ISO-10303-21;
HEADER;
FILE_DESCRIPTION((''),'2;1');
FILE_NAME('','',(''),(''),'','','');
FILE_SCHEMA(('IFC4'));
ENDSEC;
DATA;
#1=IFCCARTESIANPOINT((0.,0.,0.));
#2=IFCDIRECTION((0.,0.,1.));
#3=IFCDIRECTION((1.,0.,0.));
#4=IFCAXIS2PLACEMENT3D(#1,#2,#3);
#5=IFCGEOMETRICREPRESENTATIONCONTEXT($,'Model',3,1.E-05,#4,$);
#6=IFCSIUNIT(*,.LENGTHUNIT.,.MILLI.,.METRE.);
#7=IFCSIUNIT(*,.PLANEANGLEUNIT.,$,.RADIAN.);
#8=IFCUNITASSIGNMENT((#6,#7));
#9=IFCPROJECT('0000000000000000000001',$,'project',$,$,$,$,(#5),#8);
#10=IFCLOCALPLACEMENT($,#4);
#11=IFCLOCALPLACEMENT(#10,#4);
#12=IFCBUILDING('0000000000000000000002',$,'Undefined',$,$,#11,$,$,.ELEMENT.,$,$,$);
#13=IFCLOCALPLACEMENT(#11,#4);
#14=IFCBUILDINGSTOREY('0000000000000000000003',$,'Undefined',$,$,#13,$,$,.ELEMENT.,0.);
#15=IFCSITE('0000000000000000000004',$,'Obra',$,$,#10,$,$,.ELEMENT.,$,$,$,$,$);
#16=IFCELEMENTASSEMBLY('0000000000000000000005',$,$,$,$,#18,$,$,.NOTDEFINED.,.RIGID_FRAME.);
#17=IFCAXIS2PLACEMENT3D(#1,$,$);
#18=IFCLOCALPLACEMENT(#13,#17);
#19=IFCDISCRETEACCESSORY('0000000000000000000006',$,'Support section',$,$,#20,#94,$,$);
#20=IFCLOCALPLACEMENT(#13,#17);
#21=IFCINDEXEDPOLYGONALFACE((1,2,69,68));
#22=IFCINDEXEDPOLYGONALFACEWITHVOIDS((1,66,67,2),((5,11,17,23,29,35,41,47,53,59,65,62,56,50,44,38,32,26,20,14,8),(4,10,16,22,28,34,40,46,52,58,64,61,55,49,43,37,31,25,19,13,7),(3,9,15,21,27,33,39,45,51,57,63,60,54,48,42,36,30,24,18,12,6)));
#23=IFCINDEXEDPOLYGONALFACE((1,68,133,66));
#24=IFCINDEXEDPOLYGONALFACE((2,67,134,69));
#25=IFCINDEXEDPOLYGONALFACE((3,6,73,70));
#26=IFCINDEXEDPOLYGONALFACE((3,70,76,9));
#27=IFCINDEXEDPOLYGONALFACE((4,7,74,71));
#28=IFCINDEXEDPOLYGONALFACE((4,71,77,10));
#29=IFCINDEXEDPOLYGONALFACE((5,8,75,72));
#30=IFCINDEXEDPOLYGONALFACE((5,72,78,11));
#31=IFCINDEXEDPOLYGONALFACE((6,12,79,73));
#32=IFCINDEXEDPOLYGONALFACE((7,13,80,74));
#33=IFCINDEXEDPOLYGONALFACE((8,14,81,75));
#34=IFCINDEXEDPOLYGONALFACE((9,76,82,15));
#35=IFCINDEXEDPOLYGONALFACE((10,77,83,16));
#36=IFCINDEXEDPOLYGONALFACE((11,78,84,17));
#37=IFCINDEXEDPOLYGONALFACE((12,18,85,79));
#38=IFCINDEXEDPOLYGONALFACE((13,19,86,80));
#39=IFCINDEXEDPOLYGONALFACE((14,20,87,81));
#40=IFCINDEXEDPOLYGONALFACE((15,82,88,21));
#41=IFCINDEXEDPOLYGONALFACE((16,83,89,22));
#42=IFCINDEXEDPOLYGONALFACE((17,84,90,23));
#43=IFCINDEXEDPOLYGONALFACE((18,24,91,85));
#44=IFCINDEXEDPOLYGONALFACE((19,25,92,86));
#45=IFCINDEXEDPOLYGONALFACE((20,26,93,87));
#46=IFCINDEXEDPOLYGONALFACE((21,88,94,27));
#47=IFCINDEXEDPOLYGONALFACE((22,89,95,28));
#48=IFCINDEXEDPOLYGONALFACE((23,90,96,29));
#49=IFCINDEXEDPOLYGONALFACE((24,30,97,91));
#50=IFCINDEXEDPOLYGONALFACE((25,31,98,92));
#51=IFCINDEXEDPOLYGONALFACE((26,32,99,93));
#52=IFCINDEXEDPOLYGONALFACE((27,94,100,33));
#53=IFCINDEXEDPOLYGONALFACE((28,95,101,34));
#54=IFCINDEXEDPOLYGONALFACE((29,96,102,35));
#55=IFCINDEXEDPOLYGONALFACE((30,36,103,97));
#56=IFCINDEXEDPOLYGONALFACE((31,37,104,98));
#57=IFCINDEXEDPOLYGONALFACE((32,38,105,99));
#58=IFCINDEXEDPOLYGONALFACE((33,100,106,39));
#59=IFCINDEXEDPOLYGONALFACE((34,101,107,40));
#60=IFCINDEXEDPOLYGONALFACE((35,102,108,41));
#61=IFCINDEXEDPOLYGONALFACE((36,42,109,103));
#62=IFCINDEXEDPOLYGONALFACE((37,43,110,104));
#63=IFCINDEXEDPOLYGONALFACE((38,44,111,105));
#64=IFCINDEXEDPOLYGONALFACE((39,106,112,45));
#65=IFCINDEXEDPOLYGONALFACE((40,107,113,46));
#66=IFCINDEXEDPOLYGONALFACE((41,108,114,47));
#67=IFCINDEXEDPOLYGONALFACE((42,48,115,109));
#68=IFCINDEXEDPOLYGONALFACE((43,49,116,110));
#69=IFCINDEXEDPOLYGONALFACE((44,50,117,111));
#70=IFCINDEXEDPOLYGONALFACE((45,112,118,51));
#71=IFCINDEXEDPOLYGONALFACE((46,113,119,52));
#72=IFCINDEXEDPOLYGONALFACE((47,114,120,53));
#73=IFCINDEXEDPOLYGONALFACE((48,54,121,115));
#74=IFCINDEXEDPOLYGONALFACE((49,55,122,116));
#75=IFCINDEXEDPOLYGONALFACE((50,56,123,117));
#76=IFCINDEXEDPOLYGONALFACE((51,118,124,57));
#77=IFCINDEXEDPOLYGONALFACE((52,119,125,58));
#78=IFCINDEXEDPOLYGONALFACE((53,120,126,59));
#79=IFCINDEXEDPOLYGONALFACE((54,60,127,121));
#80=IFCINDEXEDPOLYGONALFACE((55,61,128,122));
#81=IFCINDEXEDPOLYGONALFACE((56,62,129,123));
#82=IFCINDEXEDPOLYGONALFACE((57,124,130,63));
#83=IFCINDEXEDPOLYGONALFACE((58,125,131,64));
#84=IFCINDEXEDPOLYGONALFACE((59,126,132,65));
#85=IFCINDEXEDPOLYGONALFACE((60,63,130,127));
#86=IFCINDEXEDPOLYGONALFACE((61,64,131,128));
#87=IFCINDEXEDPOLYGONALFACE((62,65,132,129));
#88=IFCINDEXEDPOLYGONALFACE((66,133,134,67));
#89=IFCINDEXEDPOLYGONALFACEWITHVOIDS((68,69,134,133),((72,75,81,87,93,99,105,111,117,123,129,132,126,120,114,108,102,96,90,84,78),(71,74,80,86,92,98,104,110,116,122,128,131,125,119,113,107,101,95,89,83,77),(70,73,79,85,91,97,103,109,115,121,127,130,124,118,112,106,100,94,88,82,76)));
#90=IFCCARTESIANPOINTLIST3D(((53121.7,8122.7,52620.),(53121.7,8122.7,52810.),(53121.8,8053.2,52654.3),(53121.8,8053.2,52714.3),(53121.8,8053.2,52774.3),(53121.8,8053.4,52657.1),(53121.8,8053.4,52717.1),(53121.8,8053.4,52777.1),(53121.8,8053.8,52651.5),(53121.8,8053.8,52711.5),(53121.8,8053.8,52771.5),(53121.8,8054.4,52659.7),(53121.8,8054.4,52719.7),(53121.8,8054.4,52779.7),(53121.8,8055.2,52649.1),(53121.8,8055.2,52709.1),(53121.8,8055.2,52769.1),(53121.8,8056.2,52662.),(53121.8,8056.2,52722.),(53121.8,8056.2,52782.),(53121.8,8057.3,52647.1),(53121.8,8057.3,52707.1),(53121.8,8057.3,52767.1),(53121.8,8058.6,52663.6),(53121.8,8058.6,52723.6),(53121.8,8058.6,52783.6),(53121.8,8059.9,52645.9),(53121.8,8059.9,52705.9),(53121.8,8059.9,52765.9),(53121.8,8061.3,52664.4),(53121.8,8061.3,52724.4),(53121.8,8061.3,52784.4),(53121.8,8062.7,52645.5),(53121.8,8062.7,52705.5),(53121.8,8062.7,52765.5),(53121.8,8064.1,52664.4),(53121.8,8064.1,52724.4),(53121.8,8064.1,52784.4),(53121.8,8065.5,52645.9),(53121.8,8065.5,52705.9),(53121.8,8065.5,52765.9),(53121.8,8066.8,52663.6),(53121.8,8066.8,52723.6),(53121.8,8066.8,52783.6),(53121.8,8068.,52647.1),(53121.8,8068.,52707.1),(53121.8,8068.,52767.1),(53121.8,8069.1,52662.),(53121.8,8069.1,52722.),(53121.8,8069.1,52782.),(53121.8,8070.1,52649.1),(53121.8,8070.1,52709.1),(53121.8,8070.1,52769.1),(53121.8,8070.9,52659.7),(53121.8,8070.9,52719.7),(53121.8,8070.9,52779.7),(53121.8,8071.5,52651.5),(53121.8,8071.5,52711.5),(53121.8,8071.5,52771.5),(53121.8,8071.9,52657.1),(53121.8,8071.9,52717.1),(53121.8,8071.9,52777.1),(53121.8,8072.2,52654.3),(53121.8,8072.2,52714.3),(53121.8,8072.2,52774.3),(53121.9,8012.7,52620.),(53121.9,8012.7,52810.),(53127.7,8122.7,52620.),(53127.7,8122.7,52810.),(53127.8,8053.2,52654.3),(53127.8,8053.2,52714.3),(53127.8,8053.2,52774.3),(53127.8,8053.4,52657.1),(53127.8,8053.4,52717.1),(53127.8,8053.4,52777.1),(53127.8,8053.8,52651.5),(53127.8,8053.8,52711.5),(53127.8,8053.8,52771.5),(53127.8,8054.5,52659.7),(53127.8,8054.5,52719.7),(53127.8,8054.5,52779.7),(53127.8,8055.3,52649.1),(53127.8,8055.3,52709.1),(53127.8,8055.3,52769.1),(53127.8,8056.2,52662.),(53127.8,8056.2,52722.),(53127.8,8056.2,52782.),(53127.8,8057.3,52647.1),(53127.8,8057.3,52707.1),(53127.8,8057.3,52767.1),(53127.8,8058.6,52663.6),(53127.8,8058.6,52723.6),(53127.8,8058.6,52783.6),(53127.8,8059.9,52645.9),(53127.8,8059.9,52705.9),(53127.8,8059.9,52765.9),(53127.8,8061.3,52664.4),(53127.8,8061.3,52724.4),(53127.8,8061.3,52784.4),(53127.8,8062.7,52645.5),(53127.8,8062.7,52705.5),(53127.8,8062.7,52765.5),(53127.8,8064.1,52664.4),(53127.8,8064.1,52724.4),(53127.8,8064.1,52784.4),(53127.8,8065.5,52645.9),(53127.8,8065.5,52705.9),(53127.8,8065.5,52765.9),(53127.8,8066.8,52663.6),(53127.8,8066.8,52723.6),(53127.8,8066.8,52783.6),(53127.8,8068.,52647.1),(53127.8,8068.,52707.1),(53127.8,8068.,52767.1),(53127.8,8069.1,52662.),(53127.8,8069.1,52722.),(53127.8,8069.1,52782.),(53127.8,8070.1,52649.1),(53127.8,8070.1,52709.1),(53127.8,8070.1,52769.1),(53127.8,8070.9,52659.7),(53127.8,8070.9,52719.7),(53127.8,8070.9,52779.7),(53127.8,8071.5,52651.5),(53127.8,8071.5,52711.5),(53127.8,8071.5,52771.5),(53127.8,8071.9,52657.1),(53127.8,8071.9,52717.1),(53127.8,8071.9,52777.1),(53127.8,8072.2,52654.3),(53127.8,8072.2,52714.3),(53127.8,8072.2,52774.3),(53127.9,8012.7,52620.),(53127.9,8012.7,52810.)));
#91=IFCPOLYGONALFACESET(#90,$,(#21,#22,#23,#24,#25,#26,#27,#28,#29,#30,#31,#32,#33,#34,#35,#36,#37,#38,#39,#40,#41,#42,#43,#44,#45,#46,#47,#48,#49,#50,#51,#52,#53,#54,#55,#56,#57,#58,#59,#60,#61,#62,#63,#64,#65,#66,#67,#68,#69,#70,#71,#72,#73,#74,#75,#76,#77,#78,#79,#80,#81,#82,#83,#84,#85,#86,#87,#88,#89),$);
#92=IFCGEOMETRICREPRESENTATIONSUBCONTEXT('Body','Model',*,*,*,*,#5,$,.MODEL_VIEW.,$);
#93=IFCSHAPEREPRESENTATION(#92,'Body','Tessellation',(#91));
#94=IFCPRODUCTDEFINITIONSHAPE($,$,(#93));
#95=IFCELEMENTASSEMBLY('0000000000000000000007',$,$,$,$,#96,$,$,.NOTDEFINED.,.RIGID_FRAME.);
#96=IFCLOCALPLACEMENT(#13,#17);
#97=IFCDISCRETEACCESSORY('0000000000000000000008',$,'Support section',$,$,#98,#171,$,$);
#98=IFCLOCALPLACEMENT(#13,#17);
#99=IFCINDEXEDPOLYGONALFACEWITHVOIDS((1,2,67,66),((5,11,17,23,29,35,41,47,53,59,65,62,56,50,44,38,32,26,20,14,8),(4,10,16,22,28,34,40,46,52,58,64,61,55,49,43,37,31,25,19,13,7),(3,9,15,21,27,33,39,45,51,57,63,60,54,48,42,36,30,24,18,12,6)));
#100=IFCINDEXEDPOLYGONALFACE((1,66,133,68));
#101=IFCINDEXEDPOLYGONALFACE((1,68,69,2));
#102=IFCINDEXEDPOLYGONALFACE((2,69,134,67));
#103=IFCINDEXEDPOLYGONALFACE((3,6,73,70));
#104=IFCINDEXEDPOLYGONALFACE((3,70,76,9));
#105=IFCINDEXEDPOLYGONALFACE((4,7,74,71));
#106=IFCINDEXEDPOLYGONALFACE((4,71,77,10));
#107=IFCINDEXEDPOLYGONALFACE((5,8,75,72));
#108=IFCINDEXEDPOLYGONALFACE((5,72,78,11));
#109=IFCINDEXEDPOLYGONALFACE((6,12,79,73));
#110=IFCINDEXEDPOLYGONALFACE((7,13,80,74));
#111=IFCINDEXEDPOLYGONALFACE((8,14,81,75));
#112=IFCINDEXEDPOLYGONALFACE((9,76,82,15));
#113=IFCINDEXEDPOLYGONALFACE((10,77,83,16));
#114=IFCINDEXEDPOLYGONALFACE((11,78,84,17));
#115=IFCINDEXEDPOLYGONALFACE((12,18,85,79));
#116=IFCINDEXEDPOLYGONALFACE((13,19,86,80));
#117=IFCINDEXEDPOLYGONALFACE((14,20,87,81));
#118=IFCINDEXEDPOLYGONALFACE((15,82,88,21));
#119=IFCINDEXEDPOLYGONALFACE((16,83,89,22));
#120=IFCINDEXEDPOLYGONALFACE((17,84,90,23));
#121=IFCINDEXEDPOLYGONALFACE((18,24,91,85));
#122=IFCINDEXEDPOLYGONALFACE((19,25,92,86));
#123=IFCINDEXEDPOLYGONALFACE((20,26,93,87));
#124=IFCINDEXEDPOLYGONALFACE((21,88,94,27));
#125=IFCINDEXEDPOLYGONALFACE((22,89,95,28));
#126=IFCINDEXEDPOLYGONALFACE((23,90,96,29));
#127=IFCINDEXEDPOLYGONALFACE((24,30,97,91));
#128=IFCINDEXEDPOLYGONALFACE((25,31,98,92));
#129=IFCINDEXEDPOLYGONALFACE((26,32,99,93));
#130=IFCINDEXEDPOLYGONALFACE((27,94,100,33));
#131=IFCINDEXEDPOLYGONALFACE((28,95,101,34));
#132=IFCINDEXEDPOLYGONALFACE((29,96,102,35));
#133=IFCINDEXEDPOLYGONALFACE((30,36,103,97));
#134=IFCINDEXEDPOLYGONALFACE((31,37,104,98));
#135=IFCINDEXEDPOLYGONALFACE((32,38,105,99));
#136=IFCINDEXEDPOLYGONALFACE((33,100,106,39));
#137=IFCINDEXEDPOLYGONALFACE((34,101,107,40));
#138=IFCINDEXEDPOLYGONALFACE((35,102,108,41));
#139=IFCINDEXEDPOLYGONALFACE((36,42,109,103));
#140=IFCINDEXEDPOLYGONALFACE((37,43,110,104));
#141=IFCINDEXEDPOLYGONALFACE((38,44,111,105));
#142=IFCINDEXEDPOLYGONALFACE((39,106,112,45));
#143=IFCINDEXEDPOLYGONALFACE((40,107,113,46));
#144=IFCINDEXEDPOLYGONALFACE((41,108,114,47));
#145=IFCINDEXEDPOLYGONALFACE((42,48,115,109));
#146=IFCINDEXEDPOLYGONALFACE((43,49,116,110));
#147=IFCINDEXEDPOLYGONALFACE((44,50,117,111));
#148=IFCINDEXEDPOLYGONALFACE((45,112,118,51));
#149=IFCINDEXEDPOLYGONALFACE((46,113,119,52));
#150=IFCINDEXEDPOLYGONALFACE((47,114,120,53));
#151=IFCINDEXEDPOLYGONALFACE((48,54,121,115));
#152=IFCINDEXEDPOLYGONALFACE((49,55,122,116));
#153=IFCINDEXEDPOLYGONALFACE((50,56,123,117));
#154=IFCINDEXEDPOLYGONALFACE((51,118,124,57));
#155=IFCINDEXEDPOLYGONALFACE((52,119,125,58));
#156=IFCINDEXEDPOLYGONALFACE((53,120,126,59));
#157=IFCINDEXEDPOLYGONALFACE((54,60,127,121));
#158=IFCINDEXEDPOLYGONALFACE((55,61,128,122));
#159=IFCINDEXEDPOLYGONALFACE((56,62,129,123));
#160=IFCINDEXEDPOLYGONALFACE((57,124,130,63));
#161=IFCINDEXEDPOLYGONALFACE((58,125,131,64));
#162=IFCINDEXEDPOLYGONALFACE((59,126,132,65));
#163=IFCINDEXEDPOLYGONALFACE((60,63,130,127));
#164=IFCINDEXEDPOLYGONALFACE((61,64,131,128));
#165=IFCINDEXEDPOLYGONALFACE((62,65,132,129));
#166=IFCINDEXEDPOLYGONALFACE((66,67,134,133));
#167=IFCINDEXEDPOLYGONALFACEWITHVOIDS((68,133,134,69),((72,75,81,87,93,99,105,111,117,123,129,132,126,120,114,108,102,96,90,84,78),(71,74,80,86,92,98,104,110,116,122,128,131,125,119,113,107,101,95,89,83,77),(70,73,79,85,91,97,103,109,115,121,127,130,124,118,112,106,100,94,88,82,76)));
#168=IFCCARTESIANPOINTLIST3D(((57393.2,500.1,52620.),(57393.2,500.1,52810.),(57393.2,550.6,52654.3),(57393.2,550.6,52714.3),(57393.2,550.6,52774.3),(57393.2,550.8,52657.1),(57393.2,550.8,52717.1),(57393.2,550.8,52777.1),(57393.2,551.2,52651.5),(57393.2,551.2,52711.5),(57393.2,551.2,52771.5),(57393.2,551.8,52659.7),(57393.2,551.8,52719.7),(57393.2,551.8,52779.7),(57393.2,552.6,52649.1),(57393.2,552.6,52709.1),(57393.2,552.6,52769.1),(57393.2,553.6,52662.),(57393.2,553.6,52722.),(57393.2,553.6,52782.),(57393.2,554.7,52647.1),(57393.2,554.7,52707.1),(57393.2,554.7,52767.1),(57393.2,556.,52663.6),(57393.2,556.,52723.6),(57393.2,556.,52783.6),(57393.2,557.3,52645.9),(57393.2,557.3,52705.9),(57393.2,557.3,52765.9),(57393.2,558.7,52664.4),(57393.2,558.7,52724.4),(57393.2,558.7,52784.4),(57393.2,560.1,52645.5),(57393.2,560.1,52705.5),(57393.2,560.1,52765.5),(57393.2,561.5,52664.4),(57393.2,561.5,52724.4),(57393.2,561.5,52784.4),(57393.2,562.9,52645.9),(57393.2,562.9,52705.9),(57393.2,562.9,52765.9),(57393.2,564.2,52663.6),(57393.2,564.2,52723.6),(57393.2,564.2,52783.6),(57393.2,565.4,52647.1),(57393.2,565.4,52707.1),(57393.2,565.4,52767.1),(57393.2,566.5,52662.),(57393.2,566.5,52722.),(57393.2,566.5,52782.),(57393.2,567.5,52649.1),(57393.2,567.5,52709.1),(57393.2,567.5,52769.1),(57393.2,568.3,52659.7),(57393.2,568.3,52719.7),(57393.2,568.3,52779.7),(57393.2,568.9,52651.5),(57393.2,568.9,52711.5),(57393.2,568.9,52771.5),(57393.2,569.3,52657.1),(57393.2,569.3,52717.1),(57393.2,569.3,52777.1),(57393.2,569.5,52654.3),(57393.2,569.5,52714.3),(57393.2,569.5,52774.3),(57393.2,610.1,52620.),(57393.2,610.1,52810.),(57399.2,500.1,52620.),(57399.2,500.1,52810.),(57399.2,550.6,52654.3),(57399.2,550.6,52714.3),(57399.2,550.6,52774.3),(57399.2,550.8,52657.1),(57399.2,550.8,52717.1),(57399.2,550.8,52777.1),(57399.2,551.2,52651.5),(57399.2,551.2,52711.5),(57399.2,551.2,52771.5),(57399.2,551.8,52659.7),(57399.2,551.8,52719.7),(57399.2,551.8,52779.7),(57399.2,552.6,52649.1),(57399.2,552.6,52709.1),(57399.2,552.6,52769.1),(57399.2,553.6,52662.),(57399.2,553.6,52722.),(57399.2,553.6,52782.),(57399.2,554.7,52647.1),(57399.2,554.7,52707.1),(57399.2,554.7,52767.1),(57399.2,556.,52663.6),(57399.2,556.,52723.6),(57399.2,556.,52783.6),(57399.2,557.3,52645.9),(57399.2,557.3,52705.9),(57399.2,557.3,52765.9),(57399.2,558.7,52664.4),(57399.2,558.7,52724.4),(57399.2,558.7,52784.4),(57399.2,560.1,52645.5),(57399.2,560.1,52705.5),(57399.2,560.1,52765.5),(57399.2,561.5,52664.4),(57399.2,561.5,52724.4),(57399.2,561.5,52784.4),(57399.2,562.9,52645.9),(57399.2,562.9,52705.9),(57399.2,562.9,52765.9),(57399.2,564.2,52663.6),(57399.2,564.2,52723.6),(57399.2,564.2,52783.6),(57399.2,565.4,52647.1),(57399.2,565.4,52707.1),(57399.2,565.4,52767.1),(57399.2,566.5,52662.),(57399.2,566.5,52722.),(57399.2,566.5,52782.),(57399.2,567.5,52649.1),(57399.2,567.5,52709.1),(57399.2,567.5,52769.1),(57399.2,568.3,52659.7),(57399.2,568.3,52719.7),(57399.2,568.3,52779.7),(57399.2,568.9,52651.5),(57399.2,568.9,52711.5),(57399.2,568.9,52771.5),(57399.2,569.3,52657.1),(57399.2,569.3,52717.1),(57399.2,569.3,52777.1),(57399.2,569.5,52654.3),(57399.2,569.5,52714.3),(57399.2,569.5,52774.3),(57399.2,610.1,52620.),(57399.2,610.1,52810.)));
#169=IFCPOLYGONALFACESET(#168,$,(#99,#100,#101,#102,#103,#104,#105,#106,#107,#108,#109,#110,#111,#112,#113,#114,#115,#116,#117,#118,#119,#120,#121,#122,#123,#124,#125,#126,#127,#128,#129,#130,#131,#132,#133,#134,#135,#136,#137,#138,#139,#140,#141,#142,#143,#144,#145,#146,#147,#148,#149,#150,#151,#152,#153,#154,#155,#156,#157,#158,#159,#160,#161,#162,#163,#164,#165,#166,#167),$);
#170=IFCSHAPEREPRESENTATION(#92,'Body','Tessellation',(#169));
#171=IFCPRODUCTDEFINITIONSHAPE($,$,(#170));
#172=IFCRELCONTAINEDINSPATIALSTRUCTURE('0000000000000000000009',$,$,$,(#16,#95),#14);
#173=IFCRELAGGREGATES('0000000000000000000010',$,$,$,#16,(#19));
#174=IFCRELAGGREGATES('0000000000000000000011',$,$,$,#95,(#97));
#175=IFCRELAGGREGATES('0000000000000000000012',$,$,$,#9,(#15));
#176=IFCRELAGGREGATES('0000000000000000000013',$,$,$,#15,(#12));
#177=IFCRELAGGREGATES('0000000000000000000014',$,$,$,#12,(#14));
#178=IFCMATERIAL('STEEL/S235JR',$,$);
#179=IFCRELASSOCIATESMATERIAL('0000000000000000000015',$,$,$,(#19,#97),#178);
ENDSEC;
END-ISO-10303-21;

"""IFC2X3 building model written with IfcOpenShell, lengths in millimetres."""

from ifc_helpers import new_model, si_unit, frame, origin_with_axes, origin_2d_with_axis, place, context, subcontext, project, spatial, rectangle, circle, extrude, source, transform, mapped, material, element, aggregate, save


model = new_model("IFC2X3")

# Units and contexts
model_context = context("Model", 3, precision=1e-05, world=origin_with_axes())
body_context = subcontext(model_context, "Body", "Model", "MODEL_VIEW")
ifc_project = project(units=[si_unit("LENGTHUNIT", "METRE", prefix="MILLI"), si_unit("PLANEANGLEUNIT", "RADIAN")], contexts=[model_context])

# Site, building, storey
site_placement = place(None, origin_with_axes())
site = spatial("IfcSite", under=ifc_project, at=site_placement, Name="Obra", CompositionType="ELEMENT")
building_placement = place(site_placement, origin_with_axes())
building = spatial("IfcBuilding", under=site, at=building_placement, Name="Undefined", CompositionType="ELEMENT")
storey_placement = place(building_placement, origin_with_axes())
storey = spatial("IfcBuildingStorey", under=building, at=storey_placement, Name="Undefined", CompositionType="ELEMENT", Elevation=0.0)

# Element assembly
ifc_material_1 = material(Name="STEEL/S235JR")
assembly_1_placement = place(storey_placement, origin_with_axes())
assembly_1 = element("IfcElementAssembly", 1, at=assembly_1_placement, inside=storey, AssemblyPlace="NOTDEFINED", PredefinedType="RIGID_FRAME")

# Discrete accessory, opening
shared_shape_1 = source(origin_with_axes(), body_context, "Body", "SweptSolid", [
    extrude(circle(Radius=9.5, at=origin_2d_with_axis()), frame((0.0, -9.2, 0.0), z_axis=(0.0, 1.0, 0.0), x_axis=(1.0, 0.0, 0.0)), (0.0, 0.0, 1.0), 6.2),
])
discrete_accessory_1_placement = place(assembly_1_placement, frame((53124.8, 8067.7, 52620.0), z_axis=(0.0, 0.0, 1.0), x_axis=(-0.001508, 0.999999, 0.0)))
discrete_accessory_1 = element("IfcDiscreteAccessory", 2, at=discrete_accessory_1_placement, material=ifc_material_1, Name="Support section", context=body_context, shape_type="SweptSolid", body=[
    extrude(rectangle(XDim=6.0, YDim=110.0, at=origin_2d_with_axis()), frame((0.0, 0.0, 190.0), z_axis=(0.0, 0.0, -1.0), x_axis=(0.0, 1.0, 0.0)), (0.0, 0.0, 1.0), 190.0),
])
opening_1_placement = place(assembly_1_placement, frame((53130.9, 8112.7, 52835.0), z_axis=(0.001508, -0.999999, 0.0), x_axis=(0.0, 0.0, -1.0)))
element("IfcOpeningElement", 3, at=opening_1_placement, cuts=discrete_accessory_1, ObjectType="Opening", context=body_context, shape_type="MappedRepresentation", body=[
    mapped(shared_shape_1, transform((60.0, 0.0, 50.0))),
    mapped(shared_shape_1, transform((120.0, 0.0, 50.0))),
    mapped(shared_shape_1, transform((180.0, 0.0, 50.0))),
])
aggregate(assembly_1, [discrete_accessory_1])

# Element assembly, discrete accessory, opening
assembly_2_placement = place(storey_placement, origin_with_axes())
assembly_2 = element("IfcElementAssembly", 4, at=assembly_2_placement, inside=storey, AssemblyPlace="NOTDEFINED", PredefinedType="RIGID_FRAME")
discrete_accessory_2_placement = place(assembly_2_placement, frame((57396.2, 555.1, 52620.0), z_axis=(0.0, 0.0, 1.0), x_axis=(0.000002, -1.0, 0.0)))
discrete_accessory_2 = element("IfcDiscreteAccessory", 5, at=discrete_accessory_2_placement, material=ifc_material_1, Name="Support section", context=body_context, shape_type="SweptSolid", body=[
    extrude(rectangle(XDim=6.0, YDim=110.0, at=origin_2d_with_axis()), frame((0.0, 0.0, 190.0), z_axis=(0.0, 0.0, -1.0), x_axis=(0.0, 1.0, 0.0)), (0.0, 0.0, 1.0), 190.0),
])
opening_2_placement = place(assembly_2_placement, frame((57390.1, 510.1, 52835.0), z_axis=(-0.000002, 1.0, 0.0), x_axis=(0.0, 0.0, -1.0)))
element("IfcOpeningElement", 6, at=opening_2_placement, cuts=discrete_accessory_2, ObjectType="Opening", context=body_context, shape_type="MappedRepresentation", body=[
    mapped(shared_shape_1, transform((60.0, 0.0, 50.0))),
    mapped(shared_shape_1, transform((120.0, 0.0, 50.0))),
    mapped(shared_shape_1, transform((180.0, 0.0, 50.0))),
])
aggregate(assembly_2, [discrete_accessory_2])

save(model, "model.ifc")
